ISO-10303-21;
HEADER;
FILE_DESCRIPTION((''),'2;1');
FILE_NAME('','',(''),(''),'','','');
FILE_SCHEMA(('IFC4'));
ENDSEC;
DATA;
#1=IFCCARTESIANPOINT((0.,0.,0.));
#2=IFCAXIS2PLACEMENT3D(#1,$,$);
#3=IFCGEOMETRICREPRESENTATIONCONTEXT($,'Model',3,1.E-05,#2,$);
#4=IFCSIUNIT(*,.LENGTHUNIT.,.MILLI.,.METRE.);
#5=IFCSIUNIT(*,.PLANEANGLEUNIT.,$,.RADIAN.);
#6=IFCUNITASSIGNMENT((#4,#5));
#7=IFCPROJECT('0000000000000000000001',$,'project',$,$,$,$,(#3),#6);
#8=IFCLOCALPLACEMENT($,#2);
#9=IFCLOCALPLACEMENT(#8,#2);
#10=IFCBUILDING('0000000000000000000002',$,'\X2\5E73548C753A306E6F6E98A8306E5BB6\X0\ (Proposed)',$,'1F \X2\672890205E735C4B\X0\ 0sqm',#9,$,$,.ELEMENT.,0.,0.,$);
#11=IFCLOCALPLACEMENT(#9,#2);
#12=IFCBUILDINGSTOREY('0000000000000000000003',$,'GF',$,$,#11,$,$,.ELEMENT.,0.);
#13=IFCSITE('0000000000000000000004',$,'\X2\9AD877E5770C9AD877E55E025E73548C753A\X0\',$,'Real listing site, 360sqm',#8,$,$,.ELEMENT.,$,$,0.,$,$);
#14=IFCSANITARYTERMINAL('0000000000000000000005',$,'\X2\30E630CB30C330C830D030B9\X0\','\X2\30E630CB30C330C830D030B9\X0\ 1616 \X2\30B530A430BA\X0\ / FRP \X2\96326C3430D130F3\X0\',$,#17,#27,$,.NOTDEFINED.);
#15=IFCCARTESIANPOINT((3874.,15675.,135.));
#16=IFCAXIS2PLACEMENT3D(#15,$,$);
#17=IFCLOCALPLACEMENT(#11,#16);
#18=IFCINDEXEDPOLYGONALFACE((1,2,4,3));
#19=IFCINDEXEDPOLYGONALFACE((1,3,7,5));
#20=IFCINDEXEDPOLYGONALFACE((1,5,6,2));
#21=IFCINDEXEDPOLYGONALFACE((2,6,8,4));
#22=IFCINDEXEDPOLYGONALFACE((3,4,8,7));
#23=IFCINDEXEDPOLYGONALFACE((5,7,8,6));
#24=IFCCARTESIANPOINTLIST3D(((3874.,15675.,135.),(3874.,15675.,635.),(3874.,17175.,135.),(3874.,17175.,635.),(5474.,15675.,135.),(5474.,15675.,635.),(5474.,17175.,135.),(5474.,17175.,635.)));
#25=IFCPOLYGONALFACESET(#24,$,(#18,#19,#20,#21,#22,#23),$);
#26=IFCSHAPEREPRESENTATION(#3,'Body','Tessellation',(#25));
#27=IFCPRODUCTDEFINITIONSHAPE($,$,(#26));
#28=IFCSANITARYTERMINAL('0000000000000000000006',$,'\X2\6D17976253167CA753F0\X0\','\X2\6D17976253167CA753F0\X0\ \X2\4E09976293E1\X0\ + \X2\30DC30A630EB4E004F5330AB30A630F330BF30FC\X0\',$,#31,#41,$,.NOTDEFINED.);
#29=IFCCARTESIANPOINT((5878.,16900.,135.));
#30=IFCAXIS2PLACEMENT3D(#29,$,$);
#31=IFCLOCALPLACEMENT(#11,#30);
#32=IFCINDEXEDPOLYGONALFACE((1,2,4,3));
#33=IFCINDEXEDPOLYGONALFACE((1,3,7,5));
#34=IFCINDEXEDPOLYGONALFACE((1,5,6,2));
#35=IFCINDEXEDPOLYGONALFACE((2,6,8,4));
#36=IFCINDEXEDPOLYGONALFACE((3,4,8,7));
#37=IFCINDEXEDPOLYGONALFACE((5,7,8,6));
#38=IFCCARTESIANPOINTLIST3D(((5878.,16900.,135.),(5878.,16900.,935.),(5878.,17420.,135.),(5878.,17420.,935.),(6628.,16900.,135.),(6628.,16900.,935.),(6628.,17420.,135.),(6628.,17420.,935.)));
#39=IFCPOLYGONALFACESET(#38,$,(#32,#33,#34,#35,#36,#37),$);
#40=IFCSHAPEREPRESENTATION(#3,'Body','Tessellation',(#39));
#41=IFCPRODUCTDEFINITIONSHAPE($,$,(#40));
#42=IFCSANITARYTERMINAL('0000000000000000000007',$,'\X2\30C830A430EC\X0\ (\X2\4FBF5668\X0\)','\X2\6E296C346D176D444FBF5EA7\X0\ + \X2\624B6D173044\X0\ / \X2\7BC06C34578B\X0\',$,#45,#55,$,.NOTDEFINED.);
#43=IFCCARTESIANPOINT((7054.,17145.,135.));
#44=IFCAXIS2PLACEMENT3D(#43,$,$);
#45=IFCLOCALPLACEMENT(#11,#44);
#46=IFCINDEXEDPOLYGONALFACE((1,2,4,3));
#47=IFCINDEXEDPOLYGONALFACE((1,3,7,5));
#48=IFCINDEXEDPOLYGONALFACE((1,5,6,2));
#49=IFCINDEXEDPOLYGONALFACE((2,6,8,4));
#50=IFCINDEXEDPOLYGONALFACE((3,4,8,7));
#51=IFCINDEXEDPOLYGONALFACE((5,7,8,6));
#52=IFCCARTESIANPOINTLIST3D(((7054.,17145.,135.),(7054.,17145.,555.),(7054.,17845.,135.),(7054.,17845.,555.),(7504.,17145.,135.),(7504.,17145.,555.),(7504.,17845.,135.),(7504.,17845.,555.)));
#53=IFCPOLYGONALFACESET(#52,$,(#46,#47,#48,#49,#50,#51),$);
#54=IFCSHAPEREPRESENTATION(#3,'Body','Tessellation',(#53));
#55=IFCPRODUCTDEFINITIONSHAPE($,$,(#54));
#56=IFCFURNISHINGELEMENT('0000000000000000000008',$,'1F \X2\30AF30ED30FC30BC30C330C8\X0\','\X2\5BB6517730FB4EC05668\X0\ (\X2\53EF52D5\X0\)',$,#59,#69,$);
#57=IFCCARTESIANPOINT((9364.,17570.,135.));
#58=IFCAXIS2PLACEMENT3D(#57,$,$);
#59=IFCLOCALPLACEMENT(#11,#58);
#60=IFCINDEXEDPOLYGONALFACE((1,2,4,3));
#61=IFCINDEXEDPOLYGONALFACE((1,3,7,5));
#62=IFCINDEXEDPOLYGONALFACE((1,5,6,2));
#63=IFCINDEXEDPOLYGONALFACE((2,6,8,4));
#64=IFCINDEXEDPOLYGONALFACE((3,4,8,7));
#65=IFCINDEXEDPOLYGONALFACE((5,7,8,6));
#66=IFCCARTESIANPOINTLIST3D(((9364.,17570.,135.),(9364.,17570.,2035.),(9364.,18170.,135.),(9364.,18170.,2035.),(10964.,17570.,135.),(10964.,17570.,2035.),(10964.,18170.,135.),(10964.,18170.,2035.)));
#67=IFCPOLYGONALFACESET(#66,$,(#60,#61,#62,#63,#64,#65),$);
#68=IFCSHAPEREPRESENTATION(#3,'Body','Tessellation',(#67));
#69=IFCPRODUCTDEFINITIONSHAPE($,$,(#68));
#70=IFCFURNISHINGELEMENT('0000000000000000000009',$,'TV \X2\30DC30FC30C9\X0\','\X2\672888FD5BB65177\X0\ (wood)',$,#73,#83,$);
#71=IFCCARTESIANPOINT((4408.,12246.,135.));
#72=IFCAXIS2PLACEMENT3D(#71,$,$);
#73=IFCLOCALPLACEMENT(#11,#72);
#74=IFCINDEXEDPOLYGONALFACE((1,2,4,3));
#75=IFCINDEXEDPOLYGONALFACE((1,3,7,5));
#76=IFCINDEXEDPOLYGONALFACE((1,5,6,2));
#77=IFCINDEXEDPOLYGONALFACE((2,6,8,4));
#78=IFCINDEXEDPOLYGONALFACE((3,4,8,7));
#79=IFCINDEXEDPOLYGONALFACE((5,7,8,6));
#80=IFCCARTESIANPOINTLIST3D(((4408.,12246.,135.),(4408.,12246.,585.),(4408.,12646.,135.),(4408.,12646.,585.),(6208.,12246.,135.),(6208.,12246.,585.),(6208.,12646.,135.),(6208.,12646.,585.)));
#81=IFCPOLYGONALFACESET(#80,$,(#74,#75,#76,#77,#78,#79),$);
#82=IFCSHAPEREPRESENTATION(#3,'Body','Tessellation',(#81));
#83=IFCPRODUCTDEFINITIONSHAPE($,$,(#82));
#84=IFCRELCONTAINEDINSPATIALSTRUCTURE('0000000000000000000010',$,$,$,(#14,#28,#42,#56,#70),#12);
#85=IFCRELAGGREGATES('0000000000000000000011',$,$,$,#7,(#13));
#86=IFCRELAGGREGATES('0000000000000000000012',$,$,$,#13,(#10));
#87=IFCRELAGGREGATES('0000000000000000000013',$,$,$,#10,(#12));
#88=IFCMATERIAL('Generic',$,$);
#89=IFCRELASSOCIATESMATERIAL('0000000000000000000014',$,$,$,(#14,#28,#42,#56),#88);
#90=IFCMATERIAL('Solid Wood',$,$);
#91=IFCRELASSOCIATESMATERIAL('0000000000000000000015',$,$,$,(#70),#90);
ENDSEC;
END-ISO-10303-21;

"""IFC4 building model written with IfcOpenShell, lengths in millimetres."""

from ifc_helpers import new_model, si_unit, frame, frame_2d, origin, place, context, project, spatial, rectangle, extrude, material, element, save


model = new_model("IFC4")

# Units and contexts
model_context = context("Model", 3, precision=1e-05, world=origin())
ifc_project = project(units=[si_unit("LENGTHUNIT", "METRE", prefix="MILLI"), si_unit("PLANEANGLEUNIT", "RADIAN")], contexts=[model_context])

# Site, building, storey
site_placement = place(None, origin())
site = spatial("IfcSite", under=ifc_project, at=site_placement, Name="高知県高知市平和町", ObjectType="Real listing site, 360sqm", CompositionType="ELEMENT", RefElevation=0.0)
building_placement = place(site_placement, origin())
building = spatial("IfcBuilding", under=site, at=building_placement, Name="平和町の潮風の家 (Proposed)", ObjectType="1F 木造平屋 0sqm", CompositionType="ELEMENT", ElevationOfRefHeight=0.0, ElevationOfTerrain=0.0)
storey_placement = place(building_placement, origin())
storey = spatial("IfcBuildingStorey", under=building, at=storey_placement, Name="GF", CompositionType="ELEMENT", Elevation=0.0)

# Shared definitions
ifc_material_1 = material(Name="Solid Wood")

# Sanitary terminals
ifc_material_2 = material(Name="Generic")
sanitary_terminal_1_placement = place(storey_placement, frame((3874.0, 15675.0, 135.0)))
element("IfcSanitaryTerminal", 1, at=sanitary_terminal_1_placement, inside=storey, material=ifc_material_2, Name="ユニットバス", Description="ユニットバス 1616 サイズ / FRP 防水パン", PredefinedType="NOTDEFINED", context=model_context, shape_type="SweptSolid", body=[
    extrude(rectangle(XDim=1600.0, YDim=1500.0, at=frame_2d((800.0, 750.0))), frame((3874.0, 15675.0, 135.0)), (0.0, 0.0, 1.0), 500.0),
])
sanitary_terminal_2_placement = place(storey_placement, frame((5878.0, 16900.0, 135.0)))
element("IfcSanitaryTerminal", 2, at=sanitary_terminal_2_placement, inside=storey, material=ifc_material_2, Name="洗面化粧台", Description="洗面化粧台 三面鏡 + ボウル一体カウンター", PredefinedType="NOTDEFINED", context=model_context, shape_type="SweptSolid", body=[
    extrude(rectangle(XDim=750.0, YDim=520.0, at=frame_2d((375.0, 260.0))), frame((5878.0, 16900.0, 135.0)), (0.0, 0.0, 1.0), 800.0),
])
sanitary_terminal_3_placement = place(storey_placement, frame((7054.0, 17145.0, 135.0)))
element("IfcSanitaryTerminal", 3, at=sanitary_terminal_3_placement, inside=storey, material=ifc_material_2, Name="トイレ (便器)", Description="温水洗浄便座 + 手洗い / 節水型", PredefinedType="NOTDEFINED", context=model_context, shape_type="SweptSolid", body=[
    extrude(rectangle(XDim=450.0, YDim=700.0, at=frame_2d((225.0, 350.0))), frame((7054.0, 17145.0, 135.0)), (0.0, 0.0, 1.0), 420.0),
])

# Furnishing elements
furnishing_1_placement = place(storey_placement, frame((9364.0, 17570.0, 135.0)))
element("IfcFurnishingElement", 4, at=furnishing_1_placement, inside=storey, material=ifc_material_2, Name="1F クローゼット", Description="家具・什器 (可動)", context=model_context, shape_type="SweptSolid", body=[
    extrude(rectangle(XDim=1600.0, YDim=600.0, at=frame_2d((800.0, 300.0))), frame((9364.0, 17570.0, 135.0)), (0.0, 0.0, 1.0), 1900.0),
])
furnishing_2_placement = place(storey_placement, frame((4408.0, 12246.0, 135.0)))
element("IfcFurnishingElement", 5, at=furnishing_2_placement, inside=storey, material=ifc_material_1, Name="TV ボード", Description="木製家具 (wood)", context=model_context, shape_type="SweptSolid", body=[
    extrude(rectangle(XDim=1800.0, YDim=400.0, at=frame_2d((900.0, 200.0))), frame((4408.0, 12246.0, 135.0)), (0.0, 0.0, 1.0), 450.0),
])

save(model, "model.ifc")
